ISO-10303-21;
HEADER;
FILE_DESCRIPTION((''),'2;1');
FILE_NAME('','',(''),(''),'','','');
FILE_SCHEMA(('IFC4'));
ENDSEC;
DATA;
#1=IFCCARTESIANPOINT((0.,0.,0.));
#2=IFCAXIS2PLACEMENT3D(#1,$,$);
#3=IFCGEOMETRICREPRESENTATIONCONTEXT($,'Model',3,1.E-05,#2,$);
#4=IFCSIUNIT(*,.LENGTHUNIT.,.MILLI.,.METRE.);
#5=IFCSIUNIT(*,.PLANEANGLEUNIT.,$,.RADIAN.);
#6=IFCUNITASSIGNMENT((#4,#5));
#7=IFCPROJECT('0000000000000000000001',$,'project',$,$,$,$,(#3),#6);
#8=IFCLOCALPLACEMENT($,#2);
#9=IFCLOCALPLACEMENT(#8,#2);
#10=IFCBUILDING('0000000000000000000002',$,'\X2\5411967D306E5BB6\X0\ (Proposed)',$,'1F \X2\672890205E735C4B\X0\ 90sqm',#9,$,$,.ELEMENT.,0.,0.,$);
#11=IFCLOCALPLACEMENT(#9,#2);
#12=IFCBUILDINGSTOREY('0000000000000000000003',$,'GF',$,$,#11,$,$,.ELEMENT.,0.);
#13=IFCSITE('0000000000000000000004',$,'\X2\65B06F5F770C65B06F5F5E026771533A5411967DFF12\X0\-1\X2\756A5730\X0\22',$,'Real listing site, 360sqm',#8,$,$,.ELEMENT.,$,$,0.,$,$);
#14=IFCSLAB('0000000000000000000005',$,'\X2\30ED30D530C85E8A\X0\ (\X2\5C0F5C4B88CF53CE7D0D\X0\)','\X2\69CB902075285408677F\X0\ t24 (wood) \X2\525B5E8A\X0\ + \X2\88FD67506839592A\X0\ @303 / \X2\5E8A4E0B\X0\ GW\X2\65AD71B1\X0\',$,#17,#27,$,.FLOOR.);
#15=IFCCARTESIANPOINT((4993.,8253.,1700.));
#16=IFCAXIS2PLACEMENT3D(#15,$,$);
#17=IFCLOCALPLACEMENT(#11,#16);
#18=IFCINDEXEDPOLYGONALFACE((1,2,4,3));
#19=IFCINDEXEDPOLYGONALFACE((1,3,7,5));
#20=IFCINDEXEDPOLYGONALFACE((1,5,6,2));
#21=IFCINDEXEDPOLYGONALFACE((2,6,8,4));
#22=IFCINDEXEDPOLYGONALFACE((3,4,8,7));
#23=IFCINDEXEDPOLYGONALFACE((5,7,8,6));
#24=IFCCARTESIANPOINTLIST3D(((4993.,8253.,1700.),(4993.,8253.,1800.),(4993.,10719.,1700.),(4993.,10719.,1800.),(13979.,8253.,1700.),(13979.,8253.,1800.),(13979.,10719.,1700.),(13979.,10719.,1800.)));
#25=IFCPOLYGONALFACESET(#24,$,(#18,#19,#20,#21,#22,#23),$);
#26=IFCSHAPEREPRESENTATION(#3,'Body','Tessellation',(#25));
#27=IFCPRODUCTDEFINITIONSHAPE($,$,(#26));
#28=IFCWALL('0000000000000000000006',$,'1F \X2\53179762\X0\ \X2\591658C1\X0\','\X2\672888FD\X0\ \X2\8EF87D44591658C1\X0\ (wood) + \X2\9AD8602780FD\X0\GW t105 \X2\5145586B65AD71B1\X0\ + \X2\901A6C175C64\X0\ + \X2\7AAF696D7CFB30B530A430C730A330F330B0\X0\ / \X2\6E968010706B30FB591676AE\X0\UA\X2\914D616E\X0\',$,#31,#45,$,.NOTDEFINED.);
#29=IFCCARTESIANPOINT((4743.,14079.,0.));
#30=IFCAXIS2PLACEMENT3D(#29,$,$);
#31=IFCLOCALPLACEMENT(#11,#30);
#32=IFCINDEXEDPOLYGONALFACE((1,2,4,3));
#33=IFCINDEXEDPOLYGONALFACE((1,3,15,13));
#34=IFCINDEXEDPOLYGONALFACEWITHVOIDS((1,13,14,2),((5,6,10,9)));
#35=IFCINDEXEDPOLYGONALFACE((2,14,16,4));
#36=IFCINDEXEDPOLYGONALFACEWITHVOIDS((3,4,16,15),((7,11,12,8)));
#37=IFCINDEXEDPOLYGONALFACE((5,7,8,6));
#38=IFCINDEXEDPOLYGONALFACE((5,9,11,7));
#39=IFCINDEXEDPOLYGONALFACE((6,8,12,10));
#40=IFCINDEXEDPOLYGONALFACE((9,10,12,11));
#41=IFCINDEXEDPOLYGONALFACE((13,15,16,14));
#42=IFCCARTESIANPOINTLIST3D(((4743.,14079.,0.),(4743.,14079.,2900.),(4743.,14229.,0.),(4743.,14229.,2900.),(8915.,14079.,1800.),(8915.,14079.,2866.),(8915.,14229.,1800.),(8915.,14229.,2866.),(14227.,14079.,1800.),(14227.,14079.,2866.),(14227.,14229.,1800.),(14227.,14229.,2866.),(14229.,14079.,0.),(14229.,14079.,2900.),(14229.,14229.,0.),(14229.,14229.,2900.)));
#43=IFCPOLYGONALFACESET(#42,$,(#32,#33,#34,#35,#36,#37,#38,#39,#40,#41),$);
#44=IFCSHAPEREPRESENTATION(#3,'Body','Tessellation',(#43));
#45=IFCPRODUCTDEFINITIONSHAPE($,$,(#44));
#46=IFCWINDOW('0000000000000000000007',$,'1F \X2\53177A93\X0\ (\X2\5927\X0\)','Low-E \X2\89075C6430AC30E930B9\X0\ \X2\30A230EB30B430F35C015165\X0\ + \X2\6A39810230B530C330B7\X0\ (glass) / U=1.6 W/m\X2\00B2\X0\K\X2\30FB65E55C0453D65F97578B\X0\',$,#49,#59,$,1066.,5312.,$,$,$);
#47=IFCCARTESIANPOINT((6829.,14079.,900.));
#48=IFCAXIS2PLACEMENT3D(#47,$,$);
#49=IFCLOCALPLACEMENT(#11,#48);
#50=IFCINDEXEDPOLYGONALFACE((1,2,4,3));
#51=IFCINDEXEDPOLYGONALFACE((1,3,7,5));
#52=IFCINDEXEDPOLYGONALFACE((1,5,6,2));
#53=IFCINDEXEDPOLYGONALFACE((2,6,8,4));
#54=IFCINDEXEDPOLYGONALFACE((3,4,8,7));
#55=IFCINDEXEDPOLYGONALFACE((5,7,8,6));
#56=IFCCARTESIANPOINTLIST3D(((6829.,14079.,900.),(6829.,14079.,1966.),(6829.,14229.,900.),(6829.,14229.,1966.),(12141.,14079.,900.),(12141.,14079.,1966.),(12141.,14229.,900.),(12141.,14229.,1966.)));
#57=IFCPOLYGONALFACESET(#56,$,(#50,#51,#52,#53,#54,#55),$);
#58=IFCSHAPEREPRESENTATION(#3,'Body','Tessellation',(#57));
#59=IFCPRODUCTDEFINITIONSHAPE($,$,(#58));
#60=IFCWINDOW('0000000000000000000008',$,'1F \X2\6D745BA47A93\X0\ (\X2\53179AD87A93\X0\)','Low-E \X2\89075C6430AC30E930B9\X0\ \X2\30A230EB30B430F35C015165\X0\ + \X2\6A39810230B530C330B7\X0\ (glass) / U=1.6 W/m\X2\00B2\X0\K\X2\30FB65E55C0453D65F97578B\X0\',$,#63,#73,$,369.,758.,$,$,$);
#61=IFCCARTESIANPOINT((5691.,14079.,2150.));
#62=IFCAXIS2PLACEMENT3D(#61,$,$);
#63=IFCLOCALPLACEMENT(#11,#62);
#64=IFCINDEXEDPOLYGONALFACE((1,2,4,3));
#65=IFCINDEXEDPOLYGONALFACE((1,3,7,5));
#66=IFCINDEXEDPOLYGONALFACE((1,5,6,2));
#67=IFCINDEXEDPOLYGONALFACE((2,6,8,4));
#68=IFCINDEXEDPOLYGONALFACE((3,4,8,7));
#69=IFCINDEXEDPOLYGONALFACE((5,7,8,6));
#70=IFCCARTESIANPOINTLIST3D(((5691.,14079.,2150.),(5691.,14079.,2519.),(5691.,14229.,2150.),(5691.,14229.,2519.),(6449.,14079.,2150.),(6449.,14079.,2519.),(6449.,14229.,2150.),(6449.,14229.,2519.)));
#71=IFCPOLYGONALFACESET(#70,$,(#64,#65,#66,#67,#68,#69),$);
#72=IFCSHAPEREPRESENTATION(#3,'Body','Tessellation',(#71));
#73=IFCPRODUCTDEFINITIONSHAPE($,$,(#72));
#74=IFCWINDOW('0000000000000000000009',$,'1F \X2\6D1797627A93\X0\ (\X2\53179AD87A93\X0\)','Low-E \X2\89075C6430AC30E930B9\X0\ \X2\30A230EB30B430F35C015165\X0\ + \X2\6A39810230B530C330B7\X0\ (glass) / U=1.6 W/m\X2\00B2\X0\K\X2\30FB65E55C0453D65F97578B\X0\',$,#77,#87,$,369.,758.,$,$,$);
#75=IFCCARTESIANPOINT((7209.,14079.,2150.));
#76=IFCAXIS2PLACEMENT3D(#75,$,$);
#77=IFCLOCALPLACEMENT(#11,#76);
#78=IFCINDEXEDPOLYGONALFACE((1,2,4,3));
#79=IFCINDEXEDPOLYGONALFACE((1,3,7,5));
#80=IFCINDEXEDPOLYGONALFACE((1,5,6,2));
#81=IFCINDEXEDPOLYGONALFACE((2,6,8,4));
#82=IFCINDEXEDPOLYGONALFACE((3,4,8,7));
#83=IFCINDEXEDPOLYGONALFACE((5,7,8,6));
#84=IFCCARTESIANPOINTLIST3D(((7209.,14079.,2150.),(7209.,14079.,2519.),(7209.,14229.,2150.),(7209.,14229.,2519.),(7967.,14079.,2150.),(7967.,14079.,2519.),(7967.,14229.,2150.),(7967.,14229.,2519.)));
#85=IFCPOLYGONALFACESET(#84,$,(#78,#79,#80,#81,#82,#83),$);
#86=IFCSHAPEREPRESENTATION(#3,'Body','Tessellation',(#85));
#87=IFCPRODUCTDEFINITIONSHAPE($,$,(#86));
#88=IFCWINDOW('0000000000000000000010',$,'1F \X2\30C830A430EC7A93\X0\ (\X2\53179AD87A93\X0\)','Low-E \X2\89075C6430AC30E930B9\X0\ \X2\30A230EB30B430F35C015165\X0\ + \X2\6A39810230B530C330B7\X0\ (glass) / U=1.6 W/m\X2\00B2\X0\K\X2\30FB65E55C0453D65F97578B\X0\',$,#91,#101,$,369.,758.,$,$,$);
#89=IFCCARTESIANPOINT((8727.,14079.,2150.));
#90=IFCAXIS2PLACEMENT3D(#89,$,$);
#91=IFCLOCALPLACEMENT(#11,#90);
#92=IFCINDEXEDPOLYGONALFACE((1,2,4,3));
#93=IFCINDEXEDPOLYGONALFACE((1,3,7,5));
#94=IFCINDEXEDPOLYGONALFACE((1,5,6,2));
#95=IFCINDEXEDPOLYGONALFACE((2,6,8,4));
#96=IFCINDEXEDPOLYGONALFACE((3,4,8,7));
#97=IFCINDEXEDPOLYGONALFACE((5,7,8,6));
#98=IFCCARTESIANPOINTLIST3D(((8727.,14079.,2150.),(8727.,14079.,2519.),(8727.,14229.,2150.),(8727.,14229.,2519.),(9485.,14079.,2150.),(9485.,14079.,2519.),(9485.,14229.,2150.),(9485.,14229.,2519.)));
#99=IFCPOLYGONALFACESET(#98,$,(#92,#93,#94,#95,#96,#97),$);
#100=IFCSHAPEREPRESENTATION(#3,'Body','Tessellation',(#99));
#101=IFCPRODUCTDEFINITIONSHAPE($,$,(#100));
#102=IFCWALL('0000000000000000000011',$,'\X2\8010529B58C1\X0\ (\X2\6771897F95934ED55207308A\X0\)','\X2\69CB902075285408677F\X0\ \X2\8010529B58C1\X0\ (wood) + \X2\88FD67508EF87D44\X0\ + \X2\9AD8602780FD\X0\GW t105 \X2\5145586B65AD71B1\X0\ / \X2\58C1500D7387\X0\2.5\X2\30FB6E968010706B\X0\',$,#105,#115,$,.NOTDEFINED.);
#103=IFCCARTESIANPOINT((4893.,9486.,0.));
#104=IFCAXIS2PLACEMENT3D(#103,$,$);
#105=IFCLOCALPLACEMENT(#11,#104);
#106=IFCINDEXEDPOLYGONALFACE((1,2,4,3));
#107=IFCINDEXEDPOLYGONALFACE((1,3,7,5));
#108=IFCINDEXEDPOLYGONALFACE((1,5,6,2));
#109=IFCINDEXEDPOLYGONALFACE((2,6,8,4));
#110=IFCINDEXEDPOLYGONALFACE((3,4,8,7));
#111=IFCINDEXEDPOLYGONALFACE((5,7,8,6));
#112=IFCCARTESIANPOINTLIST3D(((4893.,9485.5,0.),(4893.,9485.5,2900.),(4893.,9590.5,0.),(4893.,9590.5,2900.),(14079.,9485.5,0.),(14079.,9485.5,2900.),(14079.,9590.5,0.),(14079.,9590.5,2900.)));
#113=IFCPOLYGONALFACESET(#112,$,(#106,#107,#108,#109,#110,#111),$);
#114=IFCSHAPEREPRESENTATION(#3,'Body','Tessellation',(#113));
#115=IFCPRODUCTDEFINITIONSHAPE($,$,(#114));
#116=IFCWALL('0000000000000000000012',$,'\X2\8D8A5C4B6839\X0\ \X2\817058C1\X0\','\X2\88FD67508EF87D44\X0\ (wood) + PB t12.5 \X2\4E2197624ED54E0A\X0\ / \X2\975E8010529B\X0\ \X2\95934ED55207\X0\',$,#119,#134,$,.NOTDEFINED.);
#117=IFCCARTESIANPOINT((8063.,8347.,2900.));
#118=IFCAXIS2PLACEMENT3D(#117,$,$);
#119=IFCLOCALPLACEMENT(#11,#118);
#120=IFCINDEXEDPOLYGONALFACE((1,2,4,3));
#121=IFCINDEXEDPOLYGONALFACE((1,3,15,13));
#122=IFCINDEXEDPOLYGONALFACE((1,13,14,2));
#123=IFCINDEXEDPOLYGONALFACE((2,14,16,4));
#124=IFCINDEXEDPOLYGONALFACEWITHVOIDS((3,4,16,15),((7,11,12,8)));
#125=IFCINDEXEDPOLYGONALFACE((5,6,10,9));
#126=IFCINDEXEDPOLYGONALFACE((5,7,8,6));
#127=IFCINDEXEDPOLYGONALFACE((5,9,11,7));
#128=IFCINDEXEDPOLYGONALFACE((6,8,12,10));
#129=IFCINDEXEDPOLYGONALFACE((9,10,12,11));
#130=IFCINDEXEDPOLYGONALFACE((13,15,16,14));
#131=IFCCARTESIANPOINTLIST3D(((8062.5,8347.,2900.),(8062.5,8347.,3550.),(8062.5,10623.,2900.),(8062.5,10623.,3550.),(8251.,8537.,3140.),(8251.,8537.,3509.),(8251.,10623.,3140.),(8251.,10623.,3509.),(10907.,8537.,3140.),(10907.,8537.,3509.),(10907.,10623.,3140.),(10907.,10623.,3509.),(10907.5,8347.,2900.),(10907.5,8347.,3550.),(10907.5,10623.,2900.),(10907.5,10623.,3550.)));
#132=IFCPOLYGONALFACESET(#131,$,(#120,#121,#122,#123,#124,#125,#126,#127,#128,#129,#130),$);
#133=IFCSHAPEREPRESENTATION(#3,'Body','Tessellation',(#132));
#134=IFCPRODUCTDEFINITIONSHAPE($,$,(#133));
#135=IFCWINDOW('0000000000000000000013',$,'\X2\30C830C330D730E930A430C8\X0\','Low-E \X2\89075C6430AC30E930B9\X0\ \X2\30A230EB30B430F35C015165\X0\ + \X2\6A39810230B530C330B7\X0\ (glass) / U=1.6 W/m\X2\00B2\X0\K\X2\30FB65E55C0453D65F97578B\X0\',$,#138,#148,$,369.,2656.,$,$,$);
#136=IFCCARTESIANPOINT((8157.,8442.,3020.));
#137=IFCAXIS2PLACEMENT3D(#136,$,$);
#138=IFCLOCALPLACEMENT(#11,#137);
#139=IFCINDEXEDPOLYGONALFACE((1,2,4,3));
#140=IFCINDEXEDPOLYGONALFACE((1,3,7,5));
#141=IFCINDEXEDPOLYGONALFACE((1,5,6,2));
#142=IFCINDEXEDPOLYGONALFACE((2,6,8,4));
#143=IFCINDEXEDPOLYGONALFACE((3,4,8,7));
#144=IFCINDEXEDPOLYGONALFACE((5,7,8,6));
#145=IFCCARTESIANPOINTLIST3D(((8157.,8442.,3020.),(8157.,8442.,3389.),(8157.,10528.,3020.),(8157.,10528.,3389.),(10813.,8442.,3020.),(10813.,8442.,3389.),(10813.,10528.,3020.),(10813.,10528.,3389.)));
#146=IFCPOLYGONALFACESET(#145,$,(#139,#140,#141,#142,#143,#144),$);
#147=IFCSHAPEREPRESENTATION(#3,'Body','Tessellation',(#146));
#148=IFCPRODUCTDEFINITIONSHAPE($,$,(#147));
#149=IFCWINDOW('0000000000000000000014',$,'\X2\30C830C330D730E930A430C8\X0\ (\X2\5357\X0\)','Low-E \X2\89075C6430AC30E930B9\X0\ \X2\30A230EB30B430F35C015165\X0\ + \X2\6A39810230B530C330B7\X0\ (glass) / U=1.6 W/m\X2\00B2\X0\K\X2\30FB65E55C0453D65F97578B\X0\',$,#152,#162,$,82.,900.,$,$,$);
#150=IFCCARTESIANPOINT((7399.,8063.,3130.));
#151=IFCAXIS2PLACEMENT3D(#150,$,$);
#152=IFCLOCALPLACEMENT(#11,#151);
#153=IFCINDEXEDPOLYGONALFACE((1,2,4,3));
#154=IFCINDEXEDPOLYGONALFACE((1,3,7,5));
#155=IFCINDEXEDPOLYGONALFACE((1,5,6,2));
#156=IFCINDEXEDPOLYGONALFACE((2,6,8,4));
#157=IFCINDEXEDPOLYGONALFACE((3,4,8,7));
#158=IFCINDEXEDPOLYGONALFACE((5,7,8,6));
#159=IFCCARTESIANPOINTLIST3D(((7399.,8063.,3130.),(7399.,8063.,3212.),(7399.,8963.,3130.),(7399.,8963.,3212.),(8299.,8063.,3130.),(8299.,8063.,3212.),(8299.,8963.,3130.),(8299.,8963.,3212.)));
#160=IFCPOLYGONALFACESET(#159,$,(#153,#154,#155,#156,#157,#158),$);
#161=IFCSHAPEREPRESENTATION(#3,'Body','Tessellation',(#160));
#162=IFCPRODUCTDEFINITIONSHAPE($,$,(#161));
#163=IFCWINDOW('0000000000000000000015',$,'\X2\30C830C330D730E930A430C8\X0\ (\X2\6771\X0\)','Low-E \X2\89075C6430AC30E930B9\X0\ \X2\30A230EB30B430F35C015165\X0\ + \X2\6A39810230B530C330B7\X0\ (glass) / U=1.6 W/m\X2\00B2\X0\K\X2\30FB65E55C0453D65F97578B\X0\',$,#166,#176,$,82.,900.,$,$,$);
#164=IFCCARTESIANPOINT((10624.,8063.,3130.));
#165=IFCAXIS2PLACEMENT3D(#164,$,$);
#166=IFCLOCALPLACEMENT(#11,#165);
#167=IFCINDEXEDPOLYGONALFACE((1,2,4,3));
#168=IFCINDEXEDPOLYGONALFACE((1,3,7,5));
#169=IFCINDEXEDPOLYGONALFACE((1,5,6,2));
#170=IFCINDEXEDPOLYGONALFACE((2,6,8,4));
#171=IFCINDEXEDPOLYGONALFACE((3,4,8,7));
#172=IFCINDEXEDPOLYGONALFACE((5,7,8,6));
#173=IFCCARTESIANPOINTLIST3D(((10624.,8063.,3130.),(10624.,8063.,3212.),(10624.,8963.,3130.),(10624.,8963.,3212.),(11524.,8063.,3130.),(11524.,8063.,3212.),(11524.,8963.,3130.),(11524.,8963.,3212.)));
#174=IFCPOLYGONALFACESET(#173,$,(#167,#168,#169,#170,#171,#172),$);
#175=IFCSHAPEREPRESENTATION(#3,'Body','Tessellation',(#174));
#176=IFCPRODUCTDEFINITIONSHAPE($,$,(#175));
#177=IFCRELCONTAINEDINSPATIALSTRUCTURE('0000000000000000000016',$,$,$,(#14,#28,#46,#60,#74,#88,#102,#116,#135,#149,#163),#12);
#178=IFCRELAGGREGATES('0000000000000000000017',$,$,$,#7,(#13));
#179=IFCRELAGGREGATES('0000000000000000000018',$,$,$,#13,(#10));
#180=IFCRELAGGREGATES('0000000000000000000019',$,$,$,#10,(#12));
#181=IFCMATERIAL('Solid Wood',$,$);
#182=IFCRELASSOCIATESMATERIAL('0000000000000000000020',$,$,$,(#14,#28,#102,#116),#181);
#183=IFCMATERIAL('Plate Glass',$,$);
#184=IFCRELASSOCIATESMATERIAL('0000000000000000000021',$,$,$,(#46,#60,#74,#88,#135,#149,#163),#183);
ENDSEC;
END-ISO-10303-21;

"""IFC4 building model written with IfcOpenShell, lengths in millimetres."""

from ifc_helpers import new_model, si_unit, frame, frame_2d, origin, place, context, project, spatial, rectangle, extrude, material, element, fill, save


model = new_model("IFC4")

# Units and contexts
model_context = context("Model", 3, precision=1e-05, world=origin())
ifc_project = project(units=[si_unit("LENGTHUNIT", "METRE", prefix="MILLI"), si_unit("PLANEANGLEUNIT", "RADIAN")], contexts=[model_context])

# Site, building, storey
site_placement = place(None, origin())
site = spatial("IfcSite", under=ifc_project, at=site_placement, Name="新潟県新潟市東区向陽２-1番地22", ObjectType="Real listing site, 360sqm", CompositionType="ELEMENT", RefElevation=0.0)
building_placement = place(site_placement, origin())
building = spatial("IfcBuilding", under=site, at=building_placement, Name="向陽の家 (Proposed)", ObjectType="1F 木造平屋 90sqm", CompositionType="ELEMENT", ElevationOfRefHeight=0.0, ElevationOfTerrain=0.0)
storey_placement = place(building_placement, origin())
storey = spatial("IfcBuildingStorey", under=building, at=storey_placement, Name="GF", CompositionType="ELEMENT", Elevation=0.0)

# Slab
ifc_material_1 = material(Name="Solid Wood")
slab_placement = place(storey_placement, frame((4993.0, 8253.0, 1700.0)))
element("IfcSlab", 1, at=slab_placement, inside=storey, material=ifc_material_1, Name="ロフト床 (小屋裏収納)", Description="構造用合板 t24 (wood) 剛床 + 製材根太 @303 / 床下 GW断熱", PredefinedType="FLOOR", context=model_context, shape_type="SweptSolid", body=[
    extrude(rectangle(XDim=8986.0, YDim=2466.0, at=frame_2d((4493.0, 1233.0))), frame((4993.0, 8253.0, 1700.0)), (0.0, 0.0, 1.0), 100.0),
])

# Wall, openings, windows
wall_1_placement = place(storey_placement, frame((4743.0, 14079.0, 0.0)))
wall_1 = element("IfcWall", 2, at=wall_1_placement, inside=storey, material=ifc_material_1, Name="1F 北面 外壁", Description="木製 軸組外壁 (wood) + 高性能GW t105 充填断熱 + 通気層 + 窯業系サイディング / 準耐火・外皮UA配慮", PredefinedType="NOTDEFINED", context=model_context, shape_type="SweptSolid", body=[
    extrude(rectangle(XDim=9486.0, YDim=150.0, at=frame_2d((4743.0, 75.0))), frame((4743.0, 14079.0, 0.0)), (0.0, 0.0, 1.0), 2900.0),
])
opening_1_placement = place(storey_placement, frame((6829.0, 14079.0, 900.0)))
opening_1 = element("IfcOpeningElement", 3, at=opening_1_placement, cuts=wall_1, PredefinedType="NOTDEFINED", context=model_context, shape_type="SweptSolid", body=[
    extrude(rectangle(XDim=5312.0, YDim=150.0, at=frame_2d((2656.0, 75.0))), frame((6829.0, 14079.0, 900.0)), (0.0, 0.0, 1.0), 1066.0),
])
opening_2_placement = place(storey_placement, frame((5691.0, 14079.0, 2150.0)))
opening_2 = element("IfcOpeningElement", 4, at=opening_2_placement, cuts=wall_1, PredefinedType="NOTDEFINED", context=model_context, shape_type="SweptSolid", body=[
    extrude(rectangle(XDim=758.0, YDim=150.0, at=frame_2d((379.0, 75.0))), frame((5691.0, 14079.0, 2150.0)), (0.0, 0.0, 1.0), 369.0),
])
opening_3_placement = place(storey_placement, frame((7209.0, 14079.0, 2150.0)))
opening_3 = element("IfcOpeningElement", 5, at=opening_3_placement, cuts=wall_1, PredefinedType="NOTDEFINED", context=model_context, shape_type="SweptSolid", body=[
    extrude(rectangle(XDim=758.0, YDim=150.0, at=frame_2d((379.0, 75.0))), frame((7209.0, 14079.0, 2150.0)), (0.0, 0.0, 1.0), 369.0),
])
opening_4_placement = place(storey_placement, frame((8727.0, 14079.0, 2150.0)))
opening_4 = element("IfcOpeningElement", 6, at=opening_4_placement, cuts=wall_1, PredefinedType="NOTDEFINED", context=model_context, shape_type="SweptSolid", body=[
    extrude(rectangle(XDim=758.0, YDim=150.0, at=frame_2d((379.0, 75.0))), frame((8727.0, 14079.0, 2150.0)), (0.0, 0.0, 1.0), 369.0),
])
ifc_material_2 = material(Name="Plate Glass")
window_1_placement = place(storey_placement, frame((6829.0, 14079.0, 900.0)))
window_1 = element("IfcWindow", 7, at=window_1_placement, inside=storey, material=ifc_material_2, Name="1F 北窓 (大)", Description="Low-E 複層ガラス アルゴン封入 + 樹脂サッシ (glass) / U=1.6 W/m²K・日射取得型", OverallHeight=1066.0, OverallWidth=5312.0, context=model_context, shape_type="SweptSolid", body=[
    extrude(rectangle(XDim=5312.0, YDim=150.0, at=frame_2d((2656.0, 75.0))), frame((6829.0, 14079.0, 900.0)), (0.0, 0.0, 1.0), 1066.0),
])
fill(opening_1, window_1)
window_2_placement = place(storey_placement, frame((5691.0, 14079.0, 2150.0)))
window_2 = element("IfcWindow", 8, at=window_2_placement, inside=storey, material=ifc_material_2, Name="1F 浴室窓 (北高窓)", Description="Low-E 複層ガラス アルゴン封入 + 樹脂サッシ (glass) / U=1.6 W/m²K・日射取得型", OverallHeight=369.0, OverallWidth=758.0, context=model_context, shape_type="SweptSolid", body=[
    extrude(rectangle(XDim=758.0, YDim=150.0, at=frame_2d((379.0, 75.0))), frame((5691.0, 14079.0, 2150.0)), (0.0, 0.0, 1.0), 369.0),
])
fill(opening_2, window_2)
window_3_placement = place(storey_placement, frame((7209.0, 14079.0, 2150.0)))
window_3 = element("IfcWindow", 9, at=window_3_placement, inside=storey, material=ifc_material_2, Name="1F 洗面窓 (北高窓)", Description="Low-E 複層ガラス アルゴン封入 + 樹脂サッシ (glass) / U=1.6 W/m²K・日射取得型", OverallHeight=369.0, OverallWidth=758.0, context=model_context, shape_type="SweptSolid", body=[
    extrude(rectangle(XDim=758.0, YDim=150.0, at=frame_2d((379.0, 75.0))), frame((7209.0, 14079.0, 2150.0)), (0.0, 0.0, 1.0), 369.0),
])
fill(opening_3, window_3)
window_4_placement = place(storey_placement, frame((8727.0, 14079.0, 2150.0)))
window_4 = element("IfcWindow", 10, at=window_4_placement, inside=storey, material=ifc_material_2, Name="1F トイレ窓 (北高窓)", Description="Low-E 複層ガラス アルゴン封入 + 樹脂サッシ (glass) / U=1.6 W/m²K・日射取得型", OverallHeight=369.0, OverallWidth=758.0, context=model_context, shape_type="SweptSolid", body=[
    extrude(rectangle(XDim=758.0, YDim=150.0, at=frame_2d((379.0, 75.0))), frame((8727.0, 14079.0, 2150.0)), (0.0, 0.0, 1.0), 369.0),
])
fill(opening_4, window_4)

# Wall
wall_2_placement = place(storey_placement, frame((4893.0, 9486.0, 0.0)))
element("IfcWall", 11, at=wall_2_placement, inside=storey, material=ifc_material_1, Name="耐力壁 (東西間仕切り)", Description="構造用合板 耐力壁 (wood) + 製材軸組 + 高性能GW t105 充填断熱 / 壁倍率2.5・準耐火", PredefinedType="NOTDEFINED", context=model_context, shape_type="SweptSolid", body=[
    extrude(rectangle(XDim=9186.0, YDim=105.0, at=frame_2d((4593.0, 52.0))), frame((4893.0, 9486.0, 0.0)), (0.0, 0.0, 1.0), 2900.0),
])

# Wall, openings, windows
wall_3_placement = place(storey_placement, frame((8063.0, 8347.0, 2900.0)))
wall_3 = element("IfcWall", 12, at=wall_3_placement, inside=storey, material=ifc_material_1, Name="越屋根 腰壁", Description="製材軸組 (wood) + PB t12.5 両面仕上 / 非耐力 間仕切", PredefinedType="NOTDEFINED", context=model_context, shape_type="SweptSolid", body=[
    extrude(rectangle(XDim=2845.0, YDim=2276.0, at=frame_2d((1422.0, 1138.0))), frame((8063.0, 8347.0, 2900.0)), (0.0, 0.0, 1.0), 650.0),
])
opening_5_placement = place(storey_placement, frame((8157.0, 8442.0, 3020.0)))
opening_5 = element("IfcOpeningElement", 13, at=opening_5_placement, cuts=wall_3, PredefinedType="NOTDEFINED", context=model_context, shape_type="SweptSolid", body=[
    extrude(rectangle(XDim=2656.0, YDim=2086.0, at=frame_2d((1328.0, 1043.0))), frame((8157.0, 8442.0, 3020.0)), (0.0, 0.0, 1.0), 369.0),
])
opening_6_placement = place(storey_placement, frame((7399.0, 8063.0, 3130.0)))
opening_6 = element("IfcOpeningElement", 14, at=opening_6_placement, cuts=wall_3, PredefinedType="NOTDEFINED", context=model_context, shape_type="SweptSolid", body=[
    extrude(rectangle(XDim=900.0, YDim=900.0, at=frame_2d((450.0, 450.0))), frame((7399.0, 8063.0, 3130.0)), (0.0, 0.0, 1.0), 82.0),
])
opening_7_placement = place(storey_placement, frame((10624.0, 8063.0, 3130.0)))
opening_7 = element("IfcOpeningElement", 15, at=opening_7_placement, cuts=wall_3, PredefinedType="NOTDEFINED", context=model_context, shape_type="SweptSolid", body=[
    extrude(rectangle(XDim=900.0, YDim=900.0, at=frame_2d((450.0, 450.0))), frame((10624.0, 8063.0, 3130.0)), (0.0, 0.0, 1.0), 82.0),
])
window_5_placement = place(storey_placement, frame((8157.0, 8442.0, 3020.0)))
window_5 = element("IfcWindow", 16, at=window_5_placement, inside=storey, material=ifc_material_2, Name="トップライト", Description="Low-E 複層ガラス アルゴン封入 + 樹脂サッシ (glass) / U=1.6 W/m²K・日射取得型", OverallHeight=369.0, OverallWidth=2656.0, context=model_context, shape_type="SweptSolid", body=[
    extrude(rectangle(XDim=2656.0, YDim=2086.0, at=frame_2d((1328.0, 1043.0))), frame((8157.0, 8442.0, 3020.0)), (0.0, 0.0, 1.0), 369.0),
])
fill(opening_5, window_5)
window_6_placement = place(storey_placement, frame((7399.0, 8063.0, 3130.0)))
window_6 = element("IfcWindow", 17, at=window_6_placement, inside=storey, material=ifc_material_2, Name="トップライト (南)", Description="Low-E 複層ガラス アルゴン封入 + 樹脂サッシ (glass) / U=1.6 W/m²K・日射取得型", OverallHeight=82.0, OverallWidth=900.0, context=model_context, shape_type="SweptSolid", body=[
    extrude(rectangle(XDim=900.0, YDim=900.0, at=frame_2d((450.0, 450.0))), frame((7399.0, 8063.0, 3130.0)), (0.0, 0.0, 1.0), 82.0),
])
fill(opening_6, window_6)
window_7_placement = place(storey_placement, frame((10624.0, 8063.0, 3130.0)))
window_7 = element("IfcWindow", 18, at=window_7_placement, inside=storey, material=ifc_material_2, Name="トップライト (東)", Description="Low-E 複層ガラス アルゴン封入 + 樹脂サッシ (glass) / U=1.6 W/m²K・日射取得型", OverallHeight=82.0, OverallWidth=900.0, context=model_context, shape_type="SweptSolid", body=[
    extrude(rectangle(XDim=900.0, YDim=900.0, at=frame_2d((450.0, 450.0))), frame((10624.0, 8063.0, 3130.0)), (0.0, 0.0, 1.0), 82.0),
])
fill(opening_7, window_7)

save(model, "model.ifc")
